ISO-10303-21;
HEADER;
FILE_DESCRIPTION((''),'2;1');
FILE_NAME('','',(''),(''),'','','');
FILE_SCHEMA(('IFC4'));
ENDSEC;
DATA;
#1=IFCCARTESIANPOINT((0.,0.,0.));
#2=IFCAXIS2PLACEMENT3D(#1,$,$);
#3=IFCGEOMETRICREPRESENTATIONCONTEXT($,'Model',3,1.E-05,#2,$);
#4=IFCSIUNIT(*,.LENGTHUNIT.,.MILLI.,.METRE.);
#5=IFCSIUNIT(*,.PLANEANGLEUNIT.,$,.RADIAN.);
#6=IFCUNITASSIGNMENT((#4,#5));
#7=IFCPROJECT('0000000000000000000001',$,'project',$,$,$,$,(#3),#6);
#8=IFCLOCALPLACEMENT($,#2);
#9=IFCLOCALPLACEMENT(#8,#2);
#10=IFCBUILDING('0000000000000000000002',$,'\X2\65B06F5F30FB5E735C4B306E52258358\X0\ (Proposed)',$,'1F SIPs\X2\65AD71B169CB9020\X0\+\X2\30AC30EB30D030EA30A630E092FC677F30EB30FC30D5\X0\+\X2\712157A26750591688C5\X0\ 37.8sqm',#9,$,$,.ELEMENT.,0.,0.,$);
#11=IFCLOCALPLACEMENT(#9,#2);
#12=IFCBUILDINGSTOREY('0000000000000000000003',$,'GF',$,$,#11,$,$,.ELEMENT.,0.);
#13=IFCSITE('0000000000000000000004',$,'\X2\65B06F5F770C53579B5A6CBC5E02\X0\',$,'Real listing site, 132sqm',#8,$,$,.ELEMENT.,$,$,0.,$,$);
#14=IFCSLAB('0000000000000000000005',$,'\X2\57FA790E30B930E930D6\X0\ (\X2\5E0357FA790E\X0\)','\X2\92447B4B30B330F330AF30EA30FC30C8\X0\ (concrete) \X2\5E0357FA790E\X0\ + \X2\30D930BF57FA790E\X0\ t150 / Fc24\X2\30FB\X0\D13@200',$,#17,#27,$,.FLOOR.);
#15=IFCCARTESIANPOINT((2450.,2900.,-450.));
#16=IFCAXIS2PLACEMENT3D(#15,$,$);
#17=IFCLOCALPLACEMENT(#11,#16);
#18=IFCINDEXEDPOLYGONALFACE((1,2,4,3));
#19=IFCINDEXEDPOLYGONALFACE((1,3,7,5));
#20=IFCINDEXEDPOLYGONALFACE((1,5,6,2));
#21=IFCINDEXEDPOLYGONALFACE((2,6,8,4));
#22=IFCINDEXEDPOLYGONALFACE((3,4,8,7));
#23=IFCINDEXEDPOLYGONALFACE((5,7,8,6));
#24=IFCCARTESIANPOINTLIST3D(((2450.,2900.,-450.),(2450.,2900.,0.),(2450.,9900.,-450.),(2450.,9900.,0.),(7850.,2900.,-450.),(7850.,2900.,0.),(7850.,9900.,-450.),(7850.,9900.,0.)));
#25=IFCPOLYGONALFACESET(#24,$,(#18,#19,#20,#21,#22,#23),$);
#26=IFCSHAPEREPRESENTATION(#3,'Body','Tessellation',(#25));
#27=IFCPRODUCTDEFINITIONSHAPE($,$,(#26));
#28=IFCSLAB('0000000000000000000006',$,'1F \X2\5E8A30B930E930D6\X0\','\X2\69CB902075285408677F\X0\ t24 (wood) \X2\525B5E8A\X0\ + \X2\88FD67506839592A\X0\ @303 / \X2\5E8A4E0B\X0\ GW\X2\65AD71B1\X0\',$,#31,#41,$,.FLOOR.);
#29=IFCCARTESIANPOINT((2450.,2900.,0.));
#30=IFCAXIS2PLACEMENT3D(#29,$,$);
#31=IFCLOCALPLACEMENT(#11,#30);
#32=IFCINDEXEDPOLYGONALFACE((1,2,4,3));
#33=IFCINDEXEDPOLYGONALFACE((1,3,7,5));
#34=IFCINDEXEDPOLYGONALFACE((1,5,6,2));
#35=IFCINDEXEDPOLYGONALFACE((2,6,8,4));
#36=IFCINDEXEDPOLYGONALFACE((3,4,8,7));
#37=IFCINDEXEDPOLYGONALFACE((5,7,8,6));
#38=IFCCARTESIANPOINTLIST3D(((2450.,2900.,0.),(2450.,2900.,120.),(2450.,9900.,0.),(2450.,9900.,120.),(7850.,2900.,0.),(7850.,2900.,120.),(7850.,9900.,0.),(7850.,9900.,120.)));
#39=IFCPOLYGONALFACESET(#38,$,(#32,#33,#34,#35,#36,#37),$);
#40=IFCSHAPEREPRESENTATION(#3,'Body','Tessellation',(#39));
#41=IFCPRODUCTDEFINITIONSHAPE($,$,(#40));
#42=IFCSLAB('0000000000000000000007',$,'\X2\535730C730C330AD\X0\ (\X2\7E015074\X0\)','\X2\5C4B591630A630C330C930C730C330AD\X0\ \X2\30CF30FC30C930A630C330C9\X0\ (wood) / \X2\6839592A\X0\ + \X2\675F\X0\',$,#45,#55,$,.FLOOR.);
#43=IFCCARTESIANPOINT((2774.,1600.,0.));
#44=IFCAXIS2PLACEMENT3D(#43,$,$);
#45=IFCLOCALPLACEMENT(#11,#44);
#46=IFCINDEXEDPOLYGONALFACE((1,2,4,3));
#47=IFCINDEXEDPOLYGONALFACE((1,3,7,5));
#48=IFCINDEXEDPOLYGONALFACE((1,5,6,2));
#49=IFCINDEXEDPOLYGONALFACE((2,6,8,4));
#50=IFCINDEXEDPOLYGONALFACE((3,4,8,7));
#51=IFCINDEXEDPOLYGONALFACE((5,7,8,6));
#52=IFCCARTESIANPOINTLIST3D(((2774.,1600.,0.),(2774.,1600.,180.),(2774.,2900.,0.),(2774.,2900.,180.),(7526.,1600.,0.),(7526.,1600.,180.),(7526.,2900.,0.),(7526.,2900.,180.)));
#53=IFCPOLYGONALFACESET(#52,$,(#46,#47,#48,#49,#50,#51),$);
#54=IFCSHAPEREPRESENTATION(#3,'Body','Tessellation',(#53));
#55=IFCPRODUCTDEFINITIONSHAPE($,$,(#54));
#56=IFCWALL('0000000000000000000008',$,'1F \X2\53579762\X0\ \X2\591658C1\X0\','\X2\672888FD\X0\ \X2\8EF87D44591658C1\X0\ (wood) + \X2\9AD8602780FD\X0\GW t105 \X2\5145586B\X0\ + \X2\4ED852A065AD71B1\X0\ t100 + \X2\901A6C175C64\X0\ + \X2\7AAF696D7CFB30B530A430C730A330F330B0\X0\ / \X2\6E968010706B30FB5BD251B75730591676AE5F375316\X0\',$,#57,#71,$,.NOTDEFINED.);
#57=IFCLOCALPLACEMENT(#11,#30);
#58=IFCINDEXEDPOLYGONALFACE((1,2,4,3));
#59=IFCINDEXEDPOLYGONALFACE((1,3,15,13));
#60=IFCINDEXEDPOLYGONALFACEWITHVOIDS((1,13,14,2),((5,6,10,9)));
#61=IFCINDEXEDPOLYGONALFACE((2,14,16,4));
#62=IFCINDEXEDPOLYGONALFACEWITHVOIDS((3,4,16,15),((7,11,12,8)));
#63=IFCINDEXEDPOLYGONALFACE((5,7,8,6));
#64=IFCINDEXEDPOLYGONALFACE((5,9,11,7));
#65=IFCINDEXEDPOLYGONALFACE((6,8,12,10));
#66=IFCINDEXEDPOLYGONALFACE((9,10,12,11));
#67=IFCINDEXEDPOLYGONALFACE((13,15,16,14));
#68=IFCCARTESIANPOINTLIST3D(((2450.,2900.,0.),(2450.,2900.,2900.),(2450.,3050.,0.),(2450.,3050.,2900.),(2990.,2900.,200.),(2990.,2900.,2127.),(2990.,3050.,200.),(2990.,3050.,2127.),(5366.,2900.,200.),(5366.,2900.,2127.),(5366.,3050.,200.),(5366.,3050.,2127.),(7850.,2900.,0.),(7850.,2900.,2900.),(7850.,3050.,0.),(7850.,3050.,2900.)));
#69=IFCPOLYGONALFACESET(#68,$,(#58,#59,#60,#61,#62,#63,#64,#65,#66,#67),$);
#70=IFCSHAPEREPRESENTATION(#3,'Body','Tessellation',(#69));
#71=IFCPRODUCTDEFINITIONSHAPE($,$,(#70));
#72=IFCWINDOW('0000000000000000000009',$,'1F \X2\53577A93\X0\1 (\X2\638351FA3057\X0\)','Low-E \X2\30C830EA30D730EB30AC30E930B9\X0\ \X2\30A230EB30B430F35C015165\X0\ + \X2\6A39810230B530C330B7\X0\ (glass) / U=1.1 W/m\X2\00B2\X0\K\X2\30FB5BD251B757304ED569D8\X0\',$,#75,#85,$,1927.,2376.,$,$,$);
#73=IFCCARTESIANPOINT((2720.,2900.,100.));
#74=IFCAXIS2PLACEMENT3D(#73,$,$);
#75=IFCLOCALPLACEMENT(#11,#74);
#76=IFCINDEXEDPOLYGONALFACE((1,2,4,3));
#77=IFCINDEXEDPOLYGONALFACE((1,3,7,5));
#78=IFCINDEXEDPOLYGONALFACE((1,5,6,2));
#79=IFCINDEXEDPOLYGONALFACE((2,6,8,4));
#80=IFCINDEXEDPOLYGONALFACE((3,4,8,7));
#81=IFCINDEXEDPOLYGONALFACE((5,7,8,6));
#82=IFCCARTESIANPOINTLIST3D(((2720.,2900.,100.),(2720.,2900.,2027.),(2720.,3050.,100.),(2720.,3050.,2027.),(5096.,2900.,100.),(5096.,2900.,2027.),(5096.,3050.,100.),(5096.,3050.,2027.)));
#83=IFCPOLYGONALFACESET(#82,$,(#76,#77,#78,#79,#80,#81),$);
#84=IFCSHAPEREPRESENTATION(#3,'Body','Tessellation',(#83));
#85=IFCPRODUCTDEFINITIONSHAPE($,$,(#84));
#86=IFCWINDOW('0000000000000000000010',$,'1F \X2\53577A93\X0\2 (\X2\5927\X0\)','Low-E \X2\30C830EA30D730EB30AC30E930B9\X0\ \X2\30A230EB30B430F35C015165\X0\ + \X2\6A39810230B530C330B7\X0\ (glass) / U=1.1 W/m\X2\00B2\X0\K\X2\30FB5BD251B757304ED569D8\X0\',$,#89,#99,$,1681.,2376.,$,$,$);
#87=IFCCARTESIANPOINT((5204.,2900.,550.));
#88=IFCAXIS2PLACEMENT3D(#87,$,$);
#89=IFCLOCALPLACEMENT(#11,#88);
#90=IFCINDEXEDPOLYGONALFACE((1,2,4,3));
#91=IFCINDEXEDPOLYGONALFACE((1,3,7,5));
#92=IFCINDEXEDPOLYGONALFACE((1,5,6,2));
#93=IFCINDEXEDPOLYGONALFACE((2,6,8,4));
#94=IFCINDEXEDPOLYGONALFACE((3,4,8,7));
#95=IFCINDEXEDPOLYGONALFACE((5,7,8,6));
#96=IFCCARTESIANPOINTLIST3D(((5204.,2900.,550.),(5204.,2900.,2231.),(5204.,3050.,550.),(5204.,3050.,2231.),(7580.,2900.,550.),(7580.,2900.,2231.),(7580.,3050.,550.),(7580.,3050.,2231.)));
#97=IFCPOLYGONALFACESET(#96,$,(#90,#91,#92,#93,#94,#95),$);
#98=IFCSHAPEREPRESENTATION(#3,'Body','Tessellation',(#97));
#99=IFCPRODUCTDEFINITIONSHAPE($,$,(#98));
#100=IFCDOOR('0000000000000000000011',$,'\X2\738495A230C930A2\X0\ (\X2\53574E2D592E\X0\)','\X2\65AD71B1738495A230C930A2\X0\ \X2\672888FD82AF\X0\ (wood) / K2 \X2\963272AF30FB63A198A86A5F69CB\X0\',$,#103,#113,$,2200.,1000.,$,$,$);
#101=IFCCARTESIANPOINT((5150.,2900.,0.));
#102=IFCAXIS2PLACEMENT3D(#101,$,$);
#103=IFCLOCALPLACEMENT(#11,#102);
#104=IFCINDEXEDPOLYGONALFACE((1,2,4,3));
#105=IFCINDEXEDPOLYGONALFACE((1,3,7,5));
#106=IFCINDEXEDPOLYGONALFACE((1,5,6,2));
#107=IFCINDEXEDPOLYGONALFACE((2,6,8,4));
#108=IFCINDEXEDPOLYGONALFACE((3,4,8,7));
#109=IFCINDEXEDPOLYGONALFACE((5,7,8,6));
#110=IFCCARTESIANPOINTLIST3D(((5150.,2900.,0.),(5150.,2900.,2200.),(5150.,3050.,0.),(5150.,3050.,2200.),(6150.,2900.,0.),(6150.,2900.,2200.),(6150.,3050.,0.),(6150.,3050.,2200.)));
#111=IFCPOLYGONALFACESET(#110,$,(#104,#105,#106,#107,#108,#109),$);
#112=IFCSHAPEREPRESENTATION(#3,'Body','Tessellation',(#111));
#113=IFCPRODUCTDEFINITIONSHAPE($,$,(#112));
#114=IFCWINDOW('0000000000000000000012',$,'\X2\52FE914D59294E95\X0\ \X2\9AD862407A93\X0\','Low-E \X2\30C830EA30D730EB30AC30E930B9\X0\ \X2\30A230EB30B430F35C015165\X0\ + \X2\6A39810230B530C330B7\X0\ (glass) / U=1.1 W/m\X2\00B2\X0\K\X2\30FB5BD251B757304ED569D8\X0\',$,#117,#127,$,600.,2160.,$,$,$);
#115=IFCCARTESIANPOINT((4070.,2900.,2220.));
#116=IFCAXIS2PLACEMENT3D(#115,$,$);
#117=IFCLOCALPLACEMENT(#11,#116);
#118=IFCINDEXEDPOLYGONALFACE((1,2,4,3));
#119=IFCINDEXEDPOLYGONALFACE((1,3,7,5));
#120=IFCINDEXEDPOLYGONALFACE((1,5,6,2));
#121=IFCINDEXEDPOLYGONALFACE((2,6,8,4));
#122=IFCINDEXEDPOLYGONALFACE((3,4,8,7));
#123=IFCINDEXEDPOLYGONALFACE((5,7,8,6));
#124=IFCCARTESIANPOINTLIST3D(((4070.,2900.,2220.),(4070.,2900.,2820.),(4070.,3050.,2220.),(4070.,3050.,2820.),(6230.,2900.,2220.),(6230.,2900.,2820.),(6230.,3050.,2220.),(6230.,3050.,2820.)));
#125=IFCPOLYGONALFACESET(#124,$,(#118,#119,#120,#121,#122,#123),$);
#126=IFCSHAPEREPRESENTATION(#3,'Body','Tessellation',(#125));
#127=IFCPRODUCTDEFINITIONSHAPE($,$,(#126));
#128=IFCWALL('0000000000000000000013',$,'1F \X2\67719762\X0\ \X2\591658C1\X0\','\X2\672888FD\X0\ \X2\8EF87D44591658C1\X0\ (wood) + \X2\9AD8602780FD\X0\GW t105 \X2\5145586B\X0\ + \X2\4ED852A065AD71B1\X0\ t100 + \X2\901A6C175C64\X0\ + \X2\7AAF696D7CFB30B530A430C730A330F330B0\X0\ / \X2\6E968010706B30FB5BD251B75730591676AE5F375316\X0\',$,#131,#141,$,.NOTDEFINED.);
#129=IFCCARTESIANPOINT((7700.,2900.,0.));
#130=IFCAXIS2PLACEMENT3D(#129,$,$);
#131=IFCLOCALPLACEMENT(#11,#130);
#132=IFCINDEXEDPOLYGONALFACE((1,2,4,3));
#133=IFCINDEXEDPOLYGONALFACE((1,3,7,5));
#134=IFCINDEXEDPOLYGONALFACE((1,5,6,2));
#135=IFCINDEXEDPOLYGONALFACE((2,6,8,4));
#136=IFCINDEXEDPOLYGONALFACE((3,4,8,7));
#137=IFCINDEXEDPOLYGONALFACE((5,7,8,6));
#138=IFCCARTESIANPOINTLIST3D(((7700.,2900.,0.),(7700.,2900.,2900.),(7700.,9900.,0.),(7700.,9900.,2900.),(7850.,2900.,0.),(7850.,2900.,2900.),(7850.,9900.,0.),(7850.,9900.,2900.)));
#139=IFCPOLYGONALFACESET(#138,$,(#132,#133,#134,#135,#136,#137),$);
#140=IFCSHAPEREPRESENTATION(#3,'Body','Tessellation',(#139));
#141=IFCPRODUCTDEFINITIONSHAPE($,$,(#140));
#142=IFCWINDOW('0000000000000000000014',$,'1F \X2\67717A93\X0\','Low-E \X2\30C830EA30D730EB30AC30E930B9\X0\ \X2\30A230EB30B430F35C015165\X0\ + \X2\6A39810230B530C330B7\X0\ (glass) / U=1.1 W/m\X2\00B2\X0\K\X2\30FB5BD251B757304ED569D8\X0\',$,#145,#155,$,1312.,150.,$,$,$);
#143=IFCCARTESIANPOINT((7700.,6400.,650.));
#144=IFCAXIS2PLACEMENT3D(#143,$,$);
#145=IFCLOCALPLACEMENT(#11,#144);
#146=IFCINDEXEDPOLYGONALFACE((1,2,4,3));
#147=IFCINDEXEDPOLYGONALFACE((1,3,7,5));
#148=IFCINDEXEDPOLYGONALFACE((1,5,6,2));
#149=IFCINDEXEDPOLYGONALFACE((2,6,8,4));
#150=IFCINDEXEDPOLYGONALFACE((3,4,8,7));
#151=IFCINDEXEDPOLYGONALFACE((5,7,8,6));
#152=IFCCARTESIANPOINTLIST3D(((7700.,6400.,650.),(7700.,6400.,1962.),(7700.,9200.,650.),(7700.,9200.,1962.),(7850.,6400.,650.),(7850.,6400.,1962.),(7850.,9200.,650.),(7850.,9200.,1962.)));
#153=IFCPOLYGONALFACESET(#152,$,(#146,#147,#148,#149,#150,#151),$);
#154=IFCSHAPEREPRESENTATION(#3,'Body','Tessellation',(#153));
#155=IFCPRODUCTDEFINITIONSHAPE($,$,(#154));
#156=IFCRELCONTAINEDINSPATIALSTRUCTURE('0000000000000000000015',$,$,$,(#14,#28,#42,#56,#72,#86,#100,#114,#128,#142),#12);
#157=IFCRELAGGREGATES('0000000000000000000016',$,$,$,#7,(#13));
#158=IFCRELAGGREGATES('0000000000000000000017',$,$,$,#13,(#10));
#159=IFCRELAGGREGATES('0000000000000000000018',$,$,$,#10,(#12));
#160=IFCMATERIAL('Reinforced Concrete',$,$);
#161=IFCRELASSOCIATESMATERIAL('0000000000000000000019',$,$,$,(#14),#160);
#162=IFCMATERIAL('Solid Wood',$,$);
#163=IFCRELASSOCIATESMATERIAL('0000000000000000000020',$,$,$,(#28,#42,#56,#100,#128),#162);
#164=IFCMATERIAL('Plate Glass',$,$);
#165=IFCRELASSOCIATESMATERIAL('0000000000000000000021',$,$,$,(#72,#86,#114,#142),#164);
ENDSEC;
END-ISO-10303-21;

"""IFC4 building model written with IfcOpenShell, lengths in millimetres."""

from ifc_helpers import new_model, si_unit, frame, frame_2d, origin, place, context, project, spatial, rectangle, extrude, material, element, fill, save


model = new_model("IFC4")

# Units and contexts
model_context = context("Model", 3, precision=1e-05, world=origin())
ifc_project = project(units=[si_unit("LENGTHUNIT", "METRE", prefix="MILLI"), si_unit("PLANEANGLEUNIT", "RADIAN")], contexts=[model_context])

# Site, building, storey
site_placement = place(None, origin())
site = spatial("IfcSite", under=ifc_project, at=site_placement, Name="新潟県南魚沼市", ObjectType="Real listing site, 132sqm", CompositionType="ELEMENT", RefElevation=0.0)
building_placement = place(site_placement, origin())
building = spatial("IfcBuilding", under=site, at=building_placement, Name="新潟・平屋の別荘 (Proposed)", ObjectType="1F SIPs断熱構造+ガルバリウム鋼板ルーフ+無垢材外装 37.8sqm", CompositionType="ELEMENT", ElevationOfRefHeight=0.0, ElevationOfTerrain=0.0)
storey_placement = place(building_placement, origin())
storey = spatial("IfcBuildingStorey", under=building, at=storey_placement, Name="GF", CompositionType="ELEMENT", Elevation=0.0)

# Shared definitions
ifc_material_1 = material(Name="Solid Wood")

# Slabs
ifc_material_2 = material(Name="Reinforced Concrete")
slab_1_placement = place(storey_placement, frame((2450.0, 2900.0, -450.0)))
element("IfcSlab", 1, at=slab_1_placement, inside=storey, material=ifc_material_2, Name="基礎スラブ (布基礎)", Description="鉄筋コンクリート (concrete) 布基礎 + ベタ基礎 t150 / Fc24・D13@200", PredefinedType="FLOOR", context=model_context, shape_type="SweptSolid", body=[
    extrude(rectangle(XDim=5400.0, YDim=7000.0, at=frame_2d((2700.0, 3500.0))), frame((2450.0, 2900.0, -450.0)), (0.0, 0.0, 1.0), 450.0),
])
slab_2_placement = place(storey_placement, frame((2450.0, 2900.0, 0.0)))
element("IfcSlab", 2, at=slab_2_placement, inside=storey, material=ifc_material_1, Name="1F 床スラブ", Description="構造用合板 t24 (wood) 剛床 + 製材根太 @303 / 床下 GW断熱", PredefinedType="FLOOR", context=model_context, shape_type="SweptSolid", body=[
    extrude(rectangle(XDim=5400.0, YDim=7000.0, at=frame_2d((2700.0, 3500.0))), frame((2450.0, 2900.0, 0.0)), (0.0, 0.0, 1.0), 120.0),
])
slab_3_placement = place(storey_placement, frame((2774.0, 1600.0, 0.0)))
element("IfcSlab", 3, at=slab_3_placement, inside=storey, material=ifc_material_1, Name="南デッキ (縁側)", Description="屋外ウッドデッキ ハードウッド (wood) / 根太 + 束", PredefinedType="FLOOR", context=model_context, shape_type="SweptSolid", body=[
    extrude(rectangle(XDim=4752.0, YDim=1300.0, at=frame_2d((2376.0, 650.0))), frame((2774.0, 1600.0, 0.0)), (0.0, 0.0, 1.0), 180.0),
])

# Wall, openings, windows, door
wall_1_placement = place(storey_placement, frame((2450.0, 2900.0, 0.0)))
wall_1 = element("IfcWall", 4, at=wall_1_placement, inside=storey, material=ifc_material_1, Name="1F 南面 外壁", Description="木製 軸組外壁 (wood) + 高性能GW t105 充填 + 付加断熱 t100 + 通気層 + 窯業系サイディング / 準耐火・寒冷地外皮強化", PredefinedType="NOTDEFINED", context=model_context, shape_type="SweptSolid", body=[
    extrude(rectangle(XDim=5400.0, YDim=150.0, at=frame_2d((2700.0, 75.0))), frame((2450.0, 2900.0, 0.0)), (0.0, 0.0, 1.0), 2900.0),
])
opening_1_placement = place(storey_placement, frame((2720.0, 2900.0, 100.0)))
opening_1 = element("IfcOpeningElement", 5, at=opening_1_placement, cuts=wall_1, PredefinedType="NOTDEFINED", context=model_context, shape_type="SweptSolid", body=[
    extrude(rectangle(XDim=2376.0, YDim=150.0, at=frame_2d((1188.0, 75.0))), frame((2720.0, 2900.0, 100.0)), (0.0, 0.0, 1.0), 1927.0),
])
opening_2_placement = place(storey_placement, frame((5204.0, 2900.0, 550.0)))
opening_2 = element("IfcOpeningElement", 6, at=opening_2_placement, cuts=wall_1, PredefinedType="NOTDEFINED", context=model_context, shape_type="SweptSolid", body=[
    extrude(rectangle(XDim=2376.0, YDim=150.0, at=frame_2d((1188.0, 75.0))), frame((5204.0, 2900.0, 550.0)), (0.0, 0.0, 1.0), 1681.0),
])
opening_3_placement = place(storey_placement, frame((5150.0, 2900.0, 0.0)))
opening_3 = element("IfcOpeningElement", 7, at=opening_3_placement, cuts=wall_1, PredefinedType="NOTDEFINED", context=model_context, shape_type="SweptSolid", body=[
    extrude(rectangle(XDim=1000.0, YDim=150.0, at=frame_2d((500.0, 75.0))), frame((5150.0, 2900.0, 0.0)), (0.0, 0.0, 1.0), 2200.0),
])
opening_4_placement = place(storey_placement, frame((4070.0, 2900.0, 2220.0)))
opening_4 = element("IfcOpeningElement", 8, at=opening_4_placement, cuts=wall_1, PredefinedType="NOTDEFINED", context=model_context, shape_type="SweptSolid", body=[
    extrude(rectangle(XDim=2160.0, YDim=150.0, at=frame_2d((1080.0, 75.0))), frame((4070.0, 2900.0, 2220.0)), (0.0, 0.0, 1.0), 600.0),
])
ifc_material_3 = material(Name="Plate Glass")
window_1_placement = place(storey_placement, frame((2720.0, 2900.0, 100.0)))
window_1 = element("IfcWindow", 9, at=window_1_placement, inside=storey, material=ifc_material_3, Name="1F 南窓1 (掃出し)", Description="Low-E トリプルガラス アルゴン封入 + 樹脂サッシ (glass) / U=1.1 W/m²K・寒冷地仕様", OverallHeight=1927.0, OverallWidth=2376.0, context=model_context, shape_type="SweptSolid", body=[
    extrude(rectangle(XDim=2376.0, YDim=150.0, at=frame_2d((1188.0, 75.0))), frame((2720.0, 2900.0, 100.0)), (0.0, 0.0, 1.0), 1927.0),
])
fill(opening_1, window_1)
window_2_placement = place(storey_placement, frame((5204.0, 2900.0, 550.0)))
window_2 = element("IfcWindow", 10, at=window_2_placement, inside=storey, material=ifc_material_3, Name="1F 南窓2 (大)", Description="Low-E トリプルガラス アルゴン封入 + 樹脂サッシ (glass) / U=1.1 W/m²K・寒冷地仕様", OverallHeight=1681.0, OverallWidth=2376.0, context=model_context, shape_type="SweptSolid", body=[
    extrude(rectangle(XDim=2376.0, YDim=150.0, at=frame_2d((1188.0, 75.0))), frame((5204.0, 2900.0, 550.0)), (0.0, 0.0, 1.0), 1681.0),
])
fill(opening_2, window_2)
door_placement = place(storey_placement, frame((5150.0, 2900.0, 0.0)))
door = element("IfcDoor", 11, at=door_placement, inside=storey, material=ifc_material_1, Name="玄関ドア (南中央)", Description="断熱玄関ドア 木製芯 (wood) / K2 防犯・採風機構", OverallHeight=2200.0, OverallWidth=1000.0, context=model_context, shape_type="SweptSolid", body=[
    extrude(rectangle(XDim=1000.0, YDim=150.0, at=frame_2d((500.0, 75.0))), frame((5150.0, 2900.0, 0.0)), (0.0, 0.0, 1.0), 2200.0),
])
fill(opening_3, door)
window_3_placement = place(storey_placement, frame((4070.0, 2900.0, 2220.0)))
window_3 = element("IfcWindow", 12, at=window_3_placement, inside=storey, material=ifc_material_3, Name="勾配天井 高所窓", Description="Low-E トリプルガラス アルゴン封入 + 樹脂サッシ (glass) / U=1.1 W/m²K・寒冷地仕様", OverallHeight=600.0, OverallWidth=2160.0, context=model_context, shape_type="SweptSolid", body=[
    extrude(rectangle(XDim=2160.0, YDim=150.0, at=frame_2d((1080.0, 75.0))), frame((4070.0, 2900.0, 2220.0)), (0.0, 0.0, 1.0), 600.0),
])
fill(opening_4, window_3)

# Wall, opening, window
wall_2_placement = place(storey_placement, frame((7700.0, 2900.0, 0.0)))
wall_2 = element("IfcWall", 13, at=wall_2_placement, inside=storey, material=ifc_material_1, Name="1F 東面 外壁", Description="木製 軸組外壁 (wood) + 高性能GW t105 充填 + 付加断熱 t100 + 通気層 + 窯業系サイディング / 準耐火・寒冷地外皮強化", PredefinedType="NOTDEFINED", context=model_context, shape_type="SweptSolid", body=[
    extrude(rectangle(XDim=150.0, YDim=7000.0, at=frame_2d((75.0, 3500.0))), frame((7700.0, 2900.0, 0.0)), (0.0, 0.0, 1.0), 2900.0),
])
opening_5_placement = place(storey_placement, frame((7700.0, 6400.0, 650.0)))
opening_5 = element("IfcOpeningElement", 14, at=opening_5_placement, cuts=wall_2, PredefinedType="NOTDEFINED", context=model_context, shape_type="SweptSolid", body=[
    extrude(rectangle(XDim=150.0, YDim=2800.0, at=frame_2d((75.0, 1400.0))), frame((7700.0, 6400.0, 650.0)), (0.0, 0.0, 1.0), 1312.0),
])
window_4_placement = place(storey_placement, frame((7700.0, 6400.0, 650.0)))
window_4 = element("IfcWindow", 15, at=window_4_placement, inside=storey, material=ifc_material_3, Name="1F 東窓", Description="Low-E トリプルガラス アルゴン封入 + 樹脂サッシ (glass) / U=1.1 W/m²K・寒冷地仕様", OverallHeight=1312.0, OverallWidth=150.0, context=model_context, shape_type="SweptSolid", body=[
    extrude(rectangle(XDim=150.0, YDim=2800.0, at=frame_2d((75.0, 1400.0))), frame((7700.0, 6400.0, 650.0)), (0.0, 0.0, 1.0), 1312.0),
])
fill(opening_5, window_4)

save(model, "model.ifc")
